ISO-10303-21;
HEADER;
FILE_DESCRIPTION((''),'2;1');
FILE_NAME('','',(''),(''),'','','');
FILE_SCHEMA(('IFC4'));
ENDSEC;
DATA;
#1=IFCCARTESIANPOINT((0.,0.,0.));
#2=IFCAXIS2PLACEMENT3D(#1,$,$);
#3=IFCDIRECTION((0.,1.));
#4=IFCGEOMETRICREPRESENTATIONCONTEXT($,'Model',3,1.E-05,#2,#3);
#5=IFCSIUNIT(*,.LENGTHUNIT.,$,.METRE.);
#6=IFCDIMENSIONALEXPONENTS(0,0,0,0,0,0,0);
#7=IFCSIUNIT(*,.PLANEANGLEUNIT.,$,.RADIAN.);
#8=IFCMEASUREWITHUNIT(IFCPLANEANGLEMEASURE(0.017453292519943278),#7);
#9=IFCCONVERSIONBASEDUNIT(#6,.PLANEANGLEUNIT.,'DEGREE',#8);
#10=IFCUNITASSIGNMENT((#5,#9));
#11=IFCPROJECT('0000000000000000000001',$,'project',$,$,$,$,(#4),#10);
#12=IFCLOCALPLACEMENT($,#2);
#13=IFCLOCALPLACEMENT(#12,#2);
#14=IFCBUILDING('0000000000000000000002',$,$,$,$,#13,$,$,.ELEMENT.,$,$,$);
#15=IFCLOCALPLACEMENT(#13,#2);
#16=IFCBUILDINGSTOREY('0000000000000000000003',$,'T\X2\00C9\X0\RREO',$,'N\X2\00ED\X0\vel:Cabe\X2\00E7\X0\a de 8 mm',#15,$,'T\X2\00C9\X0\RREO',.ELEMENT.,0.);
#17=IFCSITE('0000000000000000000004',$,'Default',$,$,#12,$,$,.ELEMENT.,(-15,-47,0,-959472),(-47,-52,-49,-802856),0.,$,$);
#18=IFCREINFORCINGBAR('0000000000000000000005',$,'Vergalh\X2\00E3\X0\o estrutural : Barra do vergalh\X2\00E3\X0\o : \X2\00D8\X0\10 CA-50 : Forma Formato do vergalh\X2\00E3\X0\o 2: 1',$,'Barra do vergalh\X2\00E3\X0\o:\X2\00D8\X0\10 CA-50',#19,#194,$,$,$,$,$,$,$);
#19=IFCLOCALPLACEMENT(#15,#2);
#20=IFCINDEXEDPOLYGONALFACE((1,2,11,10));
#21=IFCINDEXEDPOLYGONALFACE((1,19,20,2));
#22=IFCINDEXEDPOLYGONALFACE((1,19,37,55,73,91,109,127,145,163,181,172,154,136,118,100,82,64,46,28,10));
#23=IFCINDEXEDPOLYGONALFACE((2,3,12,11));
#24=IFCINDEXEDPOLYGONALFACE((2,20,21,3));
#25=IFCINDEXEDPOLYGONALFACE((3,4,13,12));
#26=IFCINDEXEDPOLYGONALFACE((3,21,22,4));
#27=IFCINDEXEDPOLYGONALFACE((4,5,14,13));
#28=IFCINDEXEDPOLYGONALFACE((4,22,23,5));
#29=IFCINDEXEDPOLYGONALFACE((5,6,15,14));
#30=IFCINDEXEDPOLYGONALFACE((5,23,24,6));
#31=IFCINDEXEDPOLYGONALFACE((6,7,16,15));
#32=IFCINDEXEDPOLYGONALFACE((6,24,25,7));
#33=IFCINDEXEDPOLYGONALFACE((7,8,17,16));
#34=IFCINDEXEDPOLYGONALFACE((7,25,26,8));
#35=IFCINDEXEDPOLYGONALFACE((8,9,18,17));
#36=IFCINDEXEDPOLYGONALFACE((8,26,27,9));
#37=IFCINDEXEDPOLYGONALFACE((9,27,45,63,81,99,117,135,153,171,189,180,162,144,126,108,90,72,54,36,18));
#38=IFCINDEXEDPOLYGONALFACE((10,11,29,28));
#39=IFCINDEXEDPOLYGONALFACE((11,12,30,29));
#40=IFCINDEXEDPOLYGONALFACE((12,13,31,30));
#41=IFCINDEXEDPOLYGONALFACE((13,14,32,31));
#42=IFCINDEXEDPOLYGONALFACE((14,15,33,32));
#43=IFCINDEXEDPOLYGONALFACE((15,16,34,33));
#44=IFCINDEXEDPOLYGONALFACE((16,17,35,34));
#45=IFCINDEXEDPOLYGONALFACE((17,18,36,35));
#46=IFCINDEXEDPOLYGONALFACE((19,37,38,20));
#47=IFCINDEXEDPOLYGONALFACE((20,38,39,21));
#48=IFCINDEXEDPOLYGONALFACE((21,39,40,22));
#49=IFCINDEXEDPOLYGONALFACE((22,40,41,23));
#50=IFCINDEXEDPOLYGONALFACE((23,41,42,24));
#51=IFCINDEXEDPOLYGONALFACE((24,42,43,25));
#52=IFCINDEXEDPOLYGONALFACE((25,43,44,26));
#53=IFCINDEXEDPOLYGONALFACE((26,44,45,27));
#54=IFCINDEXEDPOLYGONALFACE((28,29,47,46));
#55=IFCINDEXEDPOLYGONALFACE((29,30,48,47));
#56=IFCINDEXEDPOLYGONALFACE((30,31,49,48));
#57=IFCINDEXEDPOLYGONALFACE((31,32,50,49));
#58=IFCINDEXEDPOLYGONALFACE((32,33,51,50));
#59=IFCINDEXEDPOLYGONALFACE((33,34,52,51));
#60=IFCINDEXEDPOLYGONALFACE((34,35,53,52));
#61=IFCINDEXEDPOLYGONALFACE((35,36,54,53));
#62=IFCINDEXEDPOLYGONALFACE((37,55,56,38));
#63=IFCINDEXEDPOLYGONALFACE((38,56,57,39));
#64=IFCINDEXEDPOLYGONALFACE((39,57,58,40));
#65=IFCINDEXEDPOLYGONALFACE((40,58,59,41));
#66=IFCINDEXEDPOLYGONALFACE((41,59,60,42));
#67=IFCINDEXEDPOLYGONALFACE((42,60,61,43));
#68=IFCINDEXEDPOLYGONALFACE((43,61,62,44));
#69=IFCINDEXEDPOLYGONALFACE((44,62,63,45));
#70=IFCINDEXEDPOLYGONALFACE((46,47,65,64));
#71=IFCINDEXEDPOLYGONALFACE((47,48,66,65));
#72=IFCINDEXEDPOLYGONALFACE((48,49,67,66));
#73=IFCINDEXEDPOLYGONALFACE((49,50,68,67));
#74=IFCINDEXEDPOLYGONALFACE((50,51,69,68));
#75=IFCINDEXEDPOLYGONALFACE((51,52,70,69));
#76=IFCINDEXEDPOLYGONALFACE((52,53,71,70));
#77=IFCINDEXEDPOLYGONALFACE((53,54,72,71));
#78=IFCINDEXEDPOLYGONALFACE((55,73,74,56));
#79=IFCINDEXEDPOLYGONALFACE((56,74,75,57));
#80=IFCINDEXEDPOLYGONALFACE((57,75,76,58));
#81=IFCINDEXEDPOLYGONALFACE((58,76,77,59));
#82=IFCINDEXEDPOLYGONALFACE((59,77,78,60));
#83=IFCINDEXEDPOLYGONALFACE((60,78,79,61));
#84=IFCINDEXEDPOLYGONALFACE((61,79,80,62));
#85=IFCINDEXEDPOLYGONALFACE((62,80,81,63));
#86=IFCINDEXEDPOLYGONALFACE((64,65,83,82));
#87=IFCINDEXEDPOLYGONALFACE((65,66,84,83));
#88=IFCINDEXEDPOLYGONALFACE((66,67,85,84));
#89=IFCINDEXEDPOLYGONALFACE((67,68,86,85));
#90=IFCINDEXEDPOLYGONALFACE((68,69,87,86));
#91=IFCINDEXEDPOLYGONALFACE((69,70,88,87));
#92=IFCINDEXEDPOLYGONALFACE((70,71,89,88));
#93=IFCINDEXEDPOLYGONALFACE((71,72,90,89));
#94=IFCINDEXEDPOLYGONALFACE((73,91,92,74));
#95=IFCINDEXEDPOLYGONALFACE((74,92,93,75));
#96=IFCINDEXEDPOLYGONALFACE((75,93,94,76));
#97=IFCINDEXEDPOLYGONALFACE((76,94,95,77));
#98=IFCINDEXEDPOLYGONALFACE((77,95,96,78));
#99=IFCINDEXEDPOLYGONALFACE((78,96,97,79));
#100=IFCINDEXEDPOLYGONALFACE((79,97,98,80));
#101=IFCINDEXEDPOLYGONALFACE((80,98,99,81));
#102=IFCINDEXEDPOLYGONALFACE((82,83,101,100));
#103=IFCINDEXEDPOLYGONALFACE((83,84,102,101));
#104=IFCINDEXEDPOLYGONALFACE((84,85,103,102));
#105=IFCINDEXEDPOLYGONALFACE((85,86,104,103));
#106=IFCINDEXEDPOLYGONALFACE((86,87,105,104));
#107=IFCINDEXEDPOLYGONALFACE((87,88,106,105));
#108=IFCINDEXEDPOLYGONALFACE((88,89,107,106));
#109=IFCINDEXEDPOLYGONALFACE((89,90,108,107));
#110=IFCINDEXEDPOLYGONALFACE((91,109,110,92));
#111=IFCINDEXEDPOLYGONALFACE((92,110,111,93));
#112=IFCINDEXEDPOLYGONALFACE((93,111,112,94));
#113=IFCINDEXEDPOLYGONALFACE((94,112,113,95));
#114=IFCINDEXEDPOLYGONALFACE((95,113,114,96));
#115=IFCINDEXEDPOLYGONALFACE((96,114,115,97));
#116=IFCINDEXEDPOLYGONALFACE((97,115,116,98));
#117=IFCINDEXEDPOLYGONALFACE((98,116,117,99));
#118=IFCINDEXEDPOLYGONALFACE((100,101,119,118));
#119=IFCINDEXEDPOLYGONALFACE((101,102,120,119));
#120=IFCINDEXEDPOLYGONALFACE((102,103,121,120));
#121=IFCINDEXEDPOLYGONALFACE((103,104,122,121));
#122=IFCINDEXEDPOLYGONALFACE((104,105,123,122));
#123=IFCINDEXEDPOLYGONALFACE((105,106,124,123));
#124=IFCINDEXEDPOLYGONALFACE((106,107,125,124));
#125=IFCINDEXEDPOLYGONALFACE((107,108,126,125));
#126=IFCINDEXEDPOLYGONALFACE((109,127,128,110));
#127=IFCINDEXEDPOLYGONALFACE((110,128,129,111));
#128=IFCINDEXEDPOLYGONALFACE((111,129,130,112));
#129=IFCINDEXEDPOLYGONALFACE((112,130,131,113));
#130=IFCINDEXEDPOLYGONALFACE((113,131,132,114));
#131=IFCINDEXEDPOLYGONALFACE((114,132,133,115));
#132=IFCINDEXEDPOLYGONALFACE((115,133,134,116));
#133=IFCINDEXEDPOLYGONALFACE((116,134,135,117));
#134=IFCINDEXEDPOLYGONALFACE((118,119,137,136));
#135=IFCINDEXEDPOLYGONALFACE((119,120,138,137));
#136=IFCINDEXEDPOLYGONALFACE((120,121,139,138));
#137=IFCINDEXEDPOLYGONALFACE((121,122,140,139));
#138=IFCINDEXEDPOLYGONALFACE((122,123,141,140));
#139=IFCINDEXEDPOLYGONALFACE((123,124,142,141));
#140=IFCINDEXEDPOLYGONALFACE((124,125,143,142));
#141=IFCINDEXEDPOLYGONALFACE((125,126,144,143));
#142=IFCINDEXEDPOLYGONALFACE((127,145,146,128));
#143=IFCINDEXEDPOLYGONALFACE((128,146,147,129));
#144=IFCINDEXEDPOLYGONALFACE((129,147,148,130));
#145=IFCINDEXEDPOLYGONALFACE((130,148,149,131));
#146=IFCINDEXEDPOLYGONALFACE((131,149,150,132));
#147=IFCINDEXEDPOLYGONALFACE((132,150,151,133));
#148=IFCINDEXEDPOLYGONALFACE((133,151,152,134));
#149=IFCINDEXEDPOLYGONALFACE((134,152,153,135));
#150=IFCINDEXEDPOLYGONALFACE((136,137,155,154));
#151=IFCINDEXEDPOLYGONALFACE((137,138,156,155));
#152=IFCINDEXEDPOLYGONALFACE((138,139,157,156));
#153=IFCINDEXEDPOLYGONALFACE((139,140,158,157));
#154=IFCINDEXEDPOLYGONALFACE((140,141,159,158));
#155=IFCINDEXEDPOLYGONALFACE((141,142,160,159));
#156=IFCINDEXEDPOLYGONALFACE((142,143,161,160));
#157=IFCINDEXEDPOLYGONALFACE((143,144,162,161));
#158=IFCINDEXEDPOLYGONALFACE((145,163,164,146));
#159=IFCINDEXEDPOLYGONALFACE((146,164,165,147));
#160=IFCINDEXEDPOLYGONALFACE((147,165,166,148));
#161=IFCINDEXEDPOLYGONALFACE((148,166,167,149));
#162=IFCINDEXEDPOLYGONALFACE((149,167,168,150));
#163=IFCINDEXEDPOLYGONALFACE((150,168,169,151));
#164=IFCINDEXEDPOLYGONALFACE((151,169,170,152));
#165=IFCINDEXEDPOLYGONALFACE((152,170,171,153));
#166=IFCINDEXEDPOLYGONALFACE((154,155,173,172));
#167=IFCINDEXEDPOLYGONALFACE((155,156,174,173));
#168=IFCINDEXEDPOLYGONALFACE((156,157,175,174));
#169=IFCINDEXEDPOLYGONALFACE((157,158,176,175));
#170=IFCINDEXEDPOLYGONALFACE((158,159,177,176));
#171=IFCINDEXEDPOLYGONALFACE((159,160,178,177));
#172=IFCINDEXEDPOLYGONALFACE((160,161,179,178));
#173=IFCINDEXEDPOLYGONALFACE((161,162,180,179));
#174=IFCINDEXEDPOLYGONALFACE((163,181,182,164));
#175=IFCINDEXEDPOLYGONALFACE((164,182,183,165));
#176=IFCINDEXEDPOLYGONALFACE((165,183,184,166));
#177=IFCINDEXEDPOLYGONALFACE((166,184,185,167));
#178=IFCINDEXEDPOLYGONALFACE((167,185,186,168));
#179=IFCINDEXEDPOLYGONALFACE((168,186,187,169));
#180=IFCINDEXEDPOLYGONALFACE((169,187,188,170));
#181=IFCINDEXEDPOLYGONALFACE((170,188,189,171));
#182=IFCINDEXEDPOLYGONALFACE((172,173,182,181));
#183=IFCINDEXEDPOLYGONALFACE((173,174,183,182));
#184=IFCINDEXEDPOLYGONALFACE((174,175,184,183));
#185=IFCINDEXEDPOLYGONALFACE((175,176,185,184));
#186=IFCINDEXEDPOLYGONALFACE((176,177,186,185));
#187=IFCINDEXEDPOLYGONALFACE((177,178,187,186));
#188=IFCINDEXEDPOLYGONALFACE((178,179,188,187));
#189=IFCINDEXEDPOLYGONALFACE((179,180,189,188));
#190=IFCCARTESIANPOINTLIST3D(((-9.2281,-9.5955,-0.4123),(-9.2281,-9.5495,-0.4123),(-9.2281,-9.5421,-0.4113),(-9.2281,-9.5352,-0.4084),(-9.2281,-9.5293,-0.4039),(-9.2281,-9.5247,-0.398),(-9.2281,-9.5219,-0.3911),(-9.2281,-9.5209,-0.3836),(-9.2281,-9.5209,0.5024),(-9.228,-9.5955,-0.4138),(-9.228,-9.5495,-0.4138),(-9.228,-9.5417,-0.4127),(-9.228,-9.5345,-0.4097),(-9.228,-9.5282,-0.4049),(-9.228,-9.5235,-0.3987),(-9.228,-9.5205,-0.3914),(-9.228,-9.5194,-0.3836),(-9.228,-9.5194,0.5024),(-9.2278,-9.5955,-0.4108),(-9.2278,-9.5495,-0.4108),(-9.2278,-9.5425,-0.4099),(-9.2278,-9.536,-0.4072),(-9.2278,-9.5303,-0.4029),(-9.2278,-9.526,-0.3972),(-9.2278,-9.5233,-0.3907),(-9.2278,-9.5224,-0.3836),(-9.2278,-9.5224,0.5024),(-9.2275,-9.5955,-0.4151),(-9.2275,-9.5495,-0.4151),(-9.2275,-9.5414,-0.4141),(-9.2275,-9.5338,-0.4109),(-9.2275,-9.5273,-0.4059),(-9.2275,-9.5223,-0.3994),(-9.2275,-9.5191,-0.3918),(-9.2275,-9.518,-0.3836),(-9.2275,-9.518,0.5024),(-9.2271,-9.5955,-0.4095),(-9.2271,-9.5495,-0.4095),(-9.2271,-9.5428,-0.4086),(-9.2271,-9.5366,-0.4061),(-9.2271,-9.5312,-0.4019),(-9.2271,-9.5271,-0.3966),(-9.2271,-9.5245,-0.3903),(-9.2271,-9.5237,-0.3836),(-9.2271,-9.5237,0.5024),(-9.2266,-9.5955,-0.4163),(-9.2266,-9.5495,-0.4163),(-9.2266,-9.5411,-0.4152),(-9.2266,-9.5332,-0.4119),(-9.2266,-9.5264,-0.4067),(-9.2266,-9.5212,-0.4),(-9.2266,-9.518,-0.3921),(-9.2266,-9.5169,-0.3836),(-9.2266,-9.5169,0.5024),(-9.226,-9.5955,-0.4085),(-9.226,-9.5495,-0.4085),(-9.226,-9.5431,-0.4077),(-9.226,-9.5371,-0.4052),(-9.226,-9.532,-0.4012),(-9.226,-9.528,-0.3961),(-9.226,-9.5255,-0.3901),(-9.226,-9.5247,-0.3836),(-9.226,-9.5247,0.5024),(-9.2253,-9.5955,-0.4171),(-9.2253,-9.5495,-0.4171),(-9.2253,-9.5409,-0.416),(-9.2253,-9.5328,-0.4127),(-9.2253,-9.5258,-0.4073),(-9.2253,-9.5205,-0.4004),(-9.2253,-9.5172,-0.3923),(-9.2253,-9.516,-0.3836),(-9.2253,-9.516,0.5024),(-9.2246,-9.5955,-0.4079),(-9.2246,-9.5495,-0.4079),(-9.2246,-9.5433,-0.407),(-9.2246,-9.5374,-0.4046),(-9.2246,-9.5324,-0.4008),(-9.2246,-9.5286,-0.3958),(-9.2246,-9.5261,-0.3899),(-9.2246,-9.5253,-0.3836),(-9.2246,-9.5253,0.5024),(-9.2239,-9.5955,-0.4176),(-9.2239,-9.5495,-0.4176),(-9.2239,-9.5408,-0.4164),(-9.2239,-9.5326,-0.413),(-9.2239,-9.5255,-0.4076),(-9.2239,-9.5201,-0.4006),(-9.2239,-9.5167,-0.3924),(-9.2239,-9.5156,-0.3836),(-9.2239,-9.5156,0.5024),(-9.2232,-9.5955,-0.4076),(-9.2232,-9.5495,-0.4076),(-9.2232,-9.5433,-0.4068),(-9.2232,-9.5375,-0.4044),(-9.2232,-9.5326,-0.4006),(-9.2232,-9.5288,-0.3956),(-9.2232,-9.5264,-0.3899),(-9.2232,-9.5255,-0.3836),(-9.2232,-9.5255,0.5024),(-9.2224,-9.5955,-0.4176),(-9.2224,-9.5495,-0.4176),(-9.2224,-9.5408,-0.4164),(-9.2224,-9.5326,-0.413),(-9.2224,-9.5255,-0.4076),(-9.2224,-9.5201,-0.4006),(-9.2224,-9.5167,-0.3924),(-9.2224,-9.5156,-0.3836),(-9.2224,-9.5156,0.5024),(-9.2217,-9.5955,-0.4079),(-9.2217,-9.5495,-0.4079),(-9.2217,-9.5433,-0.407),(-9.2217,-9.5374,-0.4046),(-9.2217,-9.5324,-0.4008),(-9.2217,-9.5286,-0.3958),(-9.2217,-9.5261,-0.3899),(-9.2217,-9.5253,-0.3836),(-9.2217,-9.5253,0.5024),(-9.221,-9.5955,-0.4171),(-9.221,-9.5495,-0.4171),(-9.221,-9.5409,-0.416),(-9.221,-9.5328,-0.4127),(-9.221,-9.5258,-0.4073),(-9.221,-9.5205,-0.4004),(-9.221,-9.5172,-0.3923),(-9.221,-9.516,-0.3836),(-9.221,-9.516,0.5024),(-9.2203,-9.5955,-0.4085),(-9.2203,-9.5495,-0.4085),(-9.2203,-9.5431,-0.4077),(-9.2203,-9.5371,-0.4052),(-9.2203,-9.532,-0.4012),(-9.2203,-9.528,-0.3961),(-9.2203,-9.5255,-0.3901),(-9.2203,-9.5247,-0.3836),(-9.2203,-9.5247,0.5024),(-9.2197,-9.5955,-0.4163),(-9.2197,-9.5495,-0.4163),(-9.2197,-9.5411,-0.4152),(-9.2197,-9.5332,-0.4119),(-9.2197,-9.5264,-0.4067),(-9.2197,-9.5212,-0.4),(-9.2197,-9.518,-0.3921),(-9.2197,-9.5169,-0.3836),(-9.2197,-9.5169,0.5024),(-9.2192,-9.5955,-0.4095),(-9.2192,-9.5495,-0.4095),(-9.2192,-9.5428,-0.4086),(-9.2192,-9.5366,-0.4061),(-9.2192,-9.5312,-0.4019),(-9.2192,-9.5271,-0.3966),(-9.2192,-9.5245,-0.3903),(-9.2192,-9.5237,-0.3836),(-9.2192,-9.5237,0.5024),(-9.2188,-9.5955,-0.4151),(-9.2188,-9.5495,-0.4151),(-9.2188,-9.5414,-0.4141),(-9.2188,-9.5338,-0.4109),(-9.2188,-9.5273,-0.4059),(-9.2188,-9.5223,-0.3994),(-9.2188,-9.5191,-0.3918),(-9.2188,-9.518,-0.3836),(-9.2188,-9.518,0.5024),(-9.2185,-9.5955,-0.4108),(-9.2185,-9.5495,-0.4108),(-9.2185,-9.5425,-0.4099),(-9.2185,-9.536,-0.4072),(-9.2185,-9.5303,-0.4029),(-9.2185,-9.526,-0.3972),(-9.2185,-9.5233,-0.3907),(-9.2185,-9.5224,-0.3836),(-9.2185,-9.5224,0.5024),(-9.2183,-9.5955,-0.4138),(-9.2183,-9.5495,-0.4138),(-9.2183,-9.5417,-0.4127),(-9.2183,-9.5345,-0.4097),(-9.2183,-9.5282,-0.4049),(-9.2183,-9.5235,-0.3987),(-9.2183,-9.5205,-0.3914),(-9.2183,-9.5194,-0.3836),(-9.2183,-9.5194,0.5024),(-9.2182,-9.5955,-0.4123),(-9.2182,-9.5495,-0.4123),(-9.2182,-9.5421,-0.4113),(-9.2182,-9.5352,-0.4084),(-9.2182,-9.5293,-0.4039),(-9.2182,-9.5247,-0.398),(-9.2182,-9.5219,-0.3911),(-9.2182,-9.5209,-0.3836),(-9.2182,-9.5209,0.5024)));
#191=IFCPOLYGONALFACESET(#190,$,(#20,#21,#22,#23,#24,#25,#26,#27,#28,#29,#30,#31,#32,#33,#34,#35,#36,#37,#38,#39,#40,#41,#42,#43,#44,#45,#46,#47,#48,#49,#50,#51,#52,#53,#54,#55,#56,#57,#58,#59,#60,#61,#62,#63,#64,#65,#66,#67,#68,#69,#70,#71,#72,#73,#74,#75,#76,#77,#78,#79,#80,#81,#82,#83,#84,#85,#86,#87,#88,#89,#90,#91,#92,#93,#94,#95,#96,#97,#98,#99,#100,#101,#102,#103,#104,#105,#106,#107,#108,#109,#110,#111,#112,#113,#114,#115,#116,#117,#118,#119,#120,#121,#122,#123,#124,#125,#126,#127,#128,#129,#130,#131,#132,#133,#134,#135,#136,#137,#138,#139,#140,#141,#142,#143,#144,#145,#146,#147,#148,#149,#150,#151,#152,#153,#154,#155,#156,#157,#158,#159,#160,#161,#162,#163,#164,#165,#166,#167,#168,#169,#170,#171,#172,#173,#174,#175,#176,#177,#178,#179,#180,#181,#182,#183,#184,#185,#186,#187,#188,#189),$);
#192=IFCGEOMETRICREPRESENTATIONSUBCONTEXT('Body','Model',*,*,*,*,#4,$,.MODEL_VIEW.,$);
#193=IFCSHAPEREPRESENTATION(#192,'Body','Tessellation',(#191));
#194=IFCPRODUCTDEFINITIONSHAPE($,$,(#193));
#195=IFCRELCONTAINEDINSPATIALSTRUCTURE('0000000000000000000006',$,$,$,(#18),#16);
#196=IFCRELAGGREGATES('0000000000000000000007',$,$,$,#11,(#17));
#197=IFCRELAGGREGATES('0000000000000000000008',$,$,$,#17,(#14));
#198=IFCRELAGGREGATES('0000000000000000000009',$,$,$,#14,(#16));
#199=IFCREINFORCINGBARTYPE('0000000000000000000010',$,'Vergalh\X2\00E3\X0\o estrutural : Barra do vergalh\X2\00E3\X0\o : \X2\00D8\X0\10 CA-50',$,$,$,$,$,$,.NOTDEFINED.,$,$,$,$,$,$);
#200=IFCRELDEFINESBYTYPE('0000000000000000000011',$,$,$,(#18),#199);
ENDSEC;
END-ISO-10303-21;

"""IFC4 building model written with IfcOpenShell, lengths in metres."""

from ifc_helpers import new_model, entity, si_unit, converted_unit, direction, origin, place, context, subcontext, project, spatial, type_object, element, save


model = new_model("IFC4")

# Units and contexts
model_context = context("Model", 3, precision=1e-05, world=origin(), true_north=direction((0.0, 1.0)))
body_context = subcontext(model_context, "Body", "Model", "MODEL_VIEW")
ifc_project = project(units=[si_unit("LENGTHUNIT", "METRE"), converted_unit("PLANEANGLEUNIT", "DEGREE", entity("IfcPlaneAngleMeasure", 0.017453292519943278), si_unit("PLANEANGLEUNIT", "RADIAN"), dimensions=[0, 0, 0, 0, 0, 0, 0])], contexts=[model_context])

# Site, building, storey
site_placement = place(None, origin())
site = spatial("IfcSite", under=ifc_project, at=site_placement, Name="Default", CompositionType="ELEMENT", RefLatitude=(-15, -47, 0, -959472), RefLongitude=(-47, -52, -49, -802856), RefElevation=0.0)
building_placement = place(site_placement, origin())
building = spatial("IfcBuilding", under=site, at=building_placement, CompositionType="ELEMENT")
storey_placement = place(building_placement, origin())
storey = spatial("IfcBuildingStorey", under=building, at=storey_placement, Name="TÉRREO", ObjectType="Nível:Cabeça de 8 mm", LongName="TÉRREO", CompositionType="ELEMENT", Elevation=0.0)

# Reinforcing bar
reinforcing_bar_type_1 = type_object("IfcReinforcingBarType", Name="Vergalhão estrutural : Barra do vergalhão : Ø10 CA-50", PredefinedType="NOTDEFINED")
reinforcing_bar_1_placement = place(storey_placement, origin())
element("IfcReinforcingBar", 1, at=reinforcing_bar_1_placement, inside=storey, type_object=reinforcing_bar_type_1, Name="Vergalhão estrutural : Barra do vergalhão : Ø10 CA-50 : Forma Formato do vergalhão 2: 1", ObjectType="Barra do vergalhão:Ø10 CA-50", context=body_context, shape_type="AdvancedSweptSolid", body=[
    entity("IfcSweptDiskSolid", entity("IfcIndexedPolyCurve", entity("IfcCartesianPointList3D", [[-9.2232, -9.5955, -0.4126], [-9.2232, -9.5495, -0.4126], [-9.2232, -9.529, -0.4042], [-9.2232, -9.5205, -0.3836], [-9.2232, -9.5205, 0.5024]]), [entity("IfcLineIndex", [1, 2]), entity("IfcArcIndex", [2, 3, 4]), entity("IfcLineIndex", [4, 5])], False), 0.005, None, 0.0, 92.0),
])

save(model, "model.ifc")
